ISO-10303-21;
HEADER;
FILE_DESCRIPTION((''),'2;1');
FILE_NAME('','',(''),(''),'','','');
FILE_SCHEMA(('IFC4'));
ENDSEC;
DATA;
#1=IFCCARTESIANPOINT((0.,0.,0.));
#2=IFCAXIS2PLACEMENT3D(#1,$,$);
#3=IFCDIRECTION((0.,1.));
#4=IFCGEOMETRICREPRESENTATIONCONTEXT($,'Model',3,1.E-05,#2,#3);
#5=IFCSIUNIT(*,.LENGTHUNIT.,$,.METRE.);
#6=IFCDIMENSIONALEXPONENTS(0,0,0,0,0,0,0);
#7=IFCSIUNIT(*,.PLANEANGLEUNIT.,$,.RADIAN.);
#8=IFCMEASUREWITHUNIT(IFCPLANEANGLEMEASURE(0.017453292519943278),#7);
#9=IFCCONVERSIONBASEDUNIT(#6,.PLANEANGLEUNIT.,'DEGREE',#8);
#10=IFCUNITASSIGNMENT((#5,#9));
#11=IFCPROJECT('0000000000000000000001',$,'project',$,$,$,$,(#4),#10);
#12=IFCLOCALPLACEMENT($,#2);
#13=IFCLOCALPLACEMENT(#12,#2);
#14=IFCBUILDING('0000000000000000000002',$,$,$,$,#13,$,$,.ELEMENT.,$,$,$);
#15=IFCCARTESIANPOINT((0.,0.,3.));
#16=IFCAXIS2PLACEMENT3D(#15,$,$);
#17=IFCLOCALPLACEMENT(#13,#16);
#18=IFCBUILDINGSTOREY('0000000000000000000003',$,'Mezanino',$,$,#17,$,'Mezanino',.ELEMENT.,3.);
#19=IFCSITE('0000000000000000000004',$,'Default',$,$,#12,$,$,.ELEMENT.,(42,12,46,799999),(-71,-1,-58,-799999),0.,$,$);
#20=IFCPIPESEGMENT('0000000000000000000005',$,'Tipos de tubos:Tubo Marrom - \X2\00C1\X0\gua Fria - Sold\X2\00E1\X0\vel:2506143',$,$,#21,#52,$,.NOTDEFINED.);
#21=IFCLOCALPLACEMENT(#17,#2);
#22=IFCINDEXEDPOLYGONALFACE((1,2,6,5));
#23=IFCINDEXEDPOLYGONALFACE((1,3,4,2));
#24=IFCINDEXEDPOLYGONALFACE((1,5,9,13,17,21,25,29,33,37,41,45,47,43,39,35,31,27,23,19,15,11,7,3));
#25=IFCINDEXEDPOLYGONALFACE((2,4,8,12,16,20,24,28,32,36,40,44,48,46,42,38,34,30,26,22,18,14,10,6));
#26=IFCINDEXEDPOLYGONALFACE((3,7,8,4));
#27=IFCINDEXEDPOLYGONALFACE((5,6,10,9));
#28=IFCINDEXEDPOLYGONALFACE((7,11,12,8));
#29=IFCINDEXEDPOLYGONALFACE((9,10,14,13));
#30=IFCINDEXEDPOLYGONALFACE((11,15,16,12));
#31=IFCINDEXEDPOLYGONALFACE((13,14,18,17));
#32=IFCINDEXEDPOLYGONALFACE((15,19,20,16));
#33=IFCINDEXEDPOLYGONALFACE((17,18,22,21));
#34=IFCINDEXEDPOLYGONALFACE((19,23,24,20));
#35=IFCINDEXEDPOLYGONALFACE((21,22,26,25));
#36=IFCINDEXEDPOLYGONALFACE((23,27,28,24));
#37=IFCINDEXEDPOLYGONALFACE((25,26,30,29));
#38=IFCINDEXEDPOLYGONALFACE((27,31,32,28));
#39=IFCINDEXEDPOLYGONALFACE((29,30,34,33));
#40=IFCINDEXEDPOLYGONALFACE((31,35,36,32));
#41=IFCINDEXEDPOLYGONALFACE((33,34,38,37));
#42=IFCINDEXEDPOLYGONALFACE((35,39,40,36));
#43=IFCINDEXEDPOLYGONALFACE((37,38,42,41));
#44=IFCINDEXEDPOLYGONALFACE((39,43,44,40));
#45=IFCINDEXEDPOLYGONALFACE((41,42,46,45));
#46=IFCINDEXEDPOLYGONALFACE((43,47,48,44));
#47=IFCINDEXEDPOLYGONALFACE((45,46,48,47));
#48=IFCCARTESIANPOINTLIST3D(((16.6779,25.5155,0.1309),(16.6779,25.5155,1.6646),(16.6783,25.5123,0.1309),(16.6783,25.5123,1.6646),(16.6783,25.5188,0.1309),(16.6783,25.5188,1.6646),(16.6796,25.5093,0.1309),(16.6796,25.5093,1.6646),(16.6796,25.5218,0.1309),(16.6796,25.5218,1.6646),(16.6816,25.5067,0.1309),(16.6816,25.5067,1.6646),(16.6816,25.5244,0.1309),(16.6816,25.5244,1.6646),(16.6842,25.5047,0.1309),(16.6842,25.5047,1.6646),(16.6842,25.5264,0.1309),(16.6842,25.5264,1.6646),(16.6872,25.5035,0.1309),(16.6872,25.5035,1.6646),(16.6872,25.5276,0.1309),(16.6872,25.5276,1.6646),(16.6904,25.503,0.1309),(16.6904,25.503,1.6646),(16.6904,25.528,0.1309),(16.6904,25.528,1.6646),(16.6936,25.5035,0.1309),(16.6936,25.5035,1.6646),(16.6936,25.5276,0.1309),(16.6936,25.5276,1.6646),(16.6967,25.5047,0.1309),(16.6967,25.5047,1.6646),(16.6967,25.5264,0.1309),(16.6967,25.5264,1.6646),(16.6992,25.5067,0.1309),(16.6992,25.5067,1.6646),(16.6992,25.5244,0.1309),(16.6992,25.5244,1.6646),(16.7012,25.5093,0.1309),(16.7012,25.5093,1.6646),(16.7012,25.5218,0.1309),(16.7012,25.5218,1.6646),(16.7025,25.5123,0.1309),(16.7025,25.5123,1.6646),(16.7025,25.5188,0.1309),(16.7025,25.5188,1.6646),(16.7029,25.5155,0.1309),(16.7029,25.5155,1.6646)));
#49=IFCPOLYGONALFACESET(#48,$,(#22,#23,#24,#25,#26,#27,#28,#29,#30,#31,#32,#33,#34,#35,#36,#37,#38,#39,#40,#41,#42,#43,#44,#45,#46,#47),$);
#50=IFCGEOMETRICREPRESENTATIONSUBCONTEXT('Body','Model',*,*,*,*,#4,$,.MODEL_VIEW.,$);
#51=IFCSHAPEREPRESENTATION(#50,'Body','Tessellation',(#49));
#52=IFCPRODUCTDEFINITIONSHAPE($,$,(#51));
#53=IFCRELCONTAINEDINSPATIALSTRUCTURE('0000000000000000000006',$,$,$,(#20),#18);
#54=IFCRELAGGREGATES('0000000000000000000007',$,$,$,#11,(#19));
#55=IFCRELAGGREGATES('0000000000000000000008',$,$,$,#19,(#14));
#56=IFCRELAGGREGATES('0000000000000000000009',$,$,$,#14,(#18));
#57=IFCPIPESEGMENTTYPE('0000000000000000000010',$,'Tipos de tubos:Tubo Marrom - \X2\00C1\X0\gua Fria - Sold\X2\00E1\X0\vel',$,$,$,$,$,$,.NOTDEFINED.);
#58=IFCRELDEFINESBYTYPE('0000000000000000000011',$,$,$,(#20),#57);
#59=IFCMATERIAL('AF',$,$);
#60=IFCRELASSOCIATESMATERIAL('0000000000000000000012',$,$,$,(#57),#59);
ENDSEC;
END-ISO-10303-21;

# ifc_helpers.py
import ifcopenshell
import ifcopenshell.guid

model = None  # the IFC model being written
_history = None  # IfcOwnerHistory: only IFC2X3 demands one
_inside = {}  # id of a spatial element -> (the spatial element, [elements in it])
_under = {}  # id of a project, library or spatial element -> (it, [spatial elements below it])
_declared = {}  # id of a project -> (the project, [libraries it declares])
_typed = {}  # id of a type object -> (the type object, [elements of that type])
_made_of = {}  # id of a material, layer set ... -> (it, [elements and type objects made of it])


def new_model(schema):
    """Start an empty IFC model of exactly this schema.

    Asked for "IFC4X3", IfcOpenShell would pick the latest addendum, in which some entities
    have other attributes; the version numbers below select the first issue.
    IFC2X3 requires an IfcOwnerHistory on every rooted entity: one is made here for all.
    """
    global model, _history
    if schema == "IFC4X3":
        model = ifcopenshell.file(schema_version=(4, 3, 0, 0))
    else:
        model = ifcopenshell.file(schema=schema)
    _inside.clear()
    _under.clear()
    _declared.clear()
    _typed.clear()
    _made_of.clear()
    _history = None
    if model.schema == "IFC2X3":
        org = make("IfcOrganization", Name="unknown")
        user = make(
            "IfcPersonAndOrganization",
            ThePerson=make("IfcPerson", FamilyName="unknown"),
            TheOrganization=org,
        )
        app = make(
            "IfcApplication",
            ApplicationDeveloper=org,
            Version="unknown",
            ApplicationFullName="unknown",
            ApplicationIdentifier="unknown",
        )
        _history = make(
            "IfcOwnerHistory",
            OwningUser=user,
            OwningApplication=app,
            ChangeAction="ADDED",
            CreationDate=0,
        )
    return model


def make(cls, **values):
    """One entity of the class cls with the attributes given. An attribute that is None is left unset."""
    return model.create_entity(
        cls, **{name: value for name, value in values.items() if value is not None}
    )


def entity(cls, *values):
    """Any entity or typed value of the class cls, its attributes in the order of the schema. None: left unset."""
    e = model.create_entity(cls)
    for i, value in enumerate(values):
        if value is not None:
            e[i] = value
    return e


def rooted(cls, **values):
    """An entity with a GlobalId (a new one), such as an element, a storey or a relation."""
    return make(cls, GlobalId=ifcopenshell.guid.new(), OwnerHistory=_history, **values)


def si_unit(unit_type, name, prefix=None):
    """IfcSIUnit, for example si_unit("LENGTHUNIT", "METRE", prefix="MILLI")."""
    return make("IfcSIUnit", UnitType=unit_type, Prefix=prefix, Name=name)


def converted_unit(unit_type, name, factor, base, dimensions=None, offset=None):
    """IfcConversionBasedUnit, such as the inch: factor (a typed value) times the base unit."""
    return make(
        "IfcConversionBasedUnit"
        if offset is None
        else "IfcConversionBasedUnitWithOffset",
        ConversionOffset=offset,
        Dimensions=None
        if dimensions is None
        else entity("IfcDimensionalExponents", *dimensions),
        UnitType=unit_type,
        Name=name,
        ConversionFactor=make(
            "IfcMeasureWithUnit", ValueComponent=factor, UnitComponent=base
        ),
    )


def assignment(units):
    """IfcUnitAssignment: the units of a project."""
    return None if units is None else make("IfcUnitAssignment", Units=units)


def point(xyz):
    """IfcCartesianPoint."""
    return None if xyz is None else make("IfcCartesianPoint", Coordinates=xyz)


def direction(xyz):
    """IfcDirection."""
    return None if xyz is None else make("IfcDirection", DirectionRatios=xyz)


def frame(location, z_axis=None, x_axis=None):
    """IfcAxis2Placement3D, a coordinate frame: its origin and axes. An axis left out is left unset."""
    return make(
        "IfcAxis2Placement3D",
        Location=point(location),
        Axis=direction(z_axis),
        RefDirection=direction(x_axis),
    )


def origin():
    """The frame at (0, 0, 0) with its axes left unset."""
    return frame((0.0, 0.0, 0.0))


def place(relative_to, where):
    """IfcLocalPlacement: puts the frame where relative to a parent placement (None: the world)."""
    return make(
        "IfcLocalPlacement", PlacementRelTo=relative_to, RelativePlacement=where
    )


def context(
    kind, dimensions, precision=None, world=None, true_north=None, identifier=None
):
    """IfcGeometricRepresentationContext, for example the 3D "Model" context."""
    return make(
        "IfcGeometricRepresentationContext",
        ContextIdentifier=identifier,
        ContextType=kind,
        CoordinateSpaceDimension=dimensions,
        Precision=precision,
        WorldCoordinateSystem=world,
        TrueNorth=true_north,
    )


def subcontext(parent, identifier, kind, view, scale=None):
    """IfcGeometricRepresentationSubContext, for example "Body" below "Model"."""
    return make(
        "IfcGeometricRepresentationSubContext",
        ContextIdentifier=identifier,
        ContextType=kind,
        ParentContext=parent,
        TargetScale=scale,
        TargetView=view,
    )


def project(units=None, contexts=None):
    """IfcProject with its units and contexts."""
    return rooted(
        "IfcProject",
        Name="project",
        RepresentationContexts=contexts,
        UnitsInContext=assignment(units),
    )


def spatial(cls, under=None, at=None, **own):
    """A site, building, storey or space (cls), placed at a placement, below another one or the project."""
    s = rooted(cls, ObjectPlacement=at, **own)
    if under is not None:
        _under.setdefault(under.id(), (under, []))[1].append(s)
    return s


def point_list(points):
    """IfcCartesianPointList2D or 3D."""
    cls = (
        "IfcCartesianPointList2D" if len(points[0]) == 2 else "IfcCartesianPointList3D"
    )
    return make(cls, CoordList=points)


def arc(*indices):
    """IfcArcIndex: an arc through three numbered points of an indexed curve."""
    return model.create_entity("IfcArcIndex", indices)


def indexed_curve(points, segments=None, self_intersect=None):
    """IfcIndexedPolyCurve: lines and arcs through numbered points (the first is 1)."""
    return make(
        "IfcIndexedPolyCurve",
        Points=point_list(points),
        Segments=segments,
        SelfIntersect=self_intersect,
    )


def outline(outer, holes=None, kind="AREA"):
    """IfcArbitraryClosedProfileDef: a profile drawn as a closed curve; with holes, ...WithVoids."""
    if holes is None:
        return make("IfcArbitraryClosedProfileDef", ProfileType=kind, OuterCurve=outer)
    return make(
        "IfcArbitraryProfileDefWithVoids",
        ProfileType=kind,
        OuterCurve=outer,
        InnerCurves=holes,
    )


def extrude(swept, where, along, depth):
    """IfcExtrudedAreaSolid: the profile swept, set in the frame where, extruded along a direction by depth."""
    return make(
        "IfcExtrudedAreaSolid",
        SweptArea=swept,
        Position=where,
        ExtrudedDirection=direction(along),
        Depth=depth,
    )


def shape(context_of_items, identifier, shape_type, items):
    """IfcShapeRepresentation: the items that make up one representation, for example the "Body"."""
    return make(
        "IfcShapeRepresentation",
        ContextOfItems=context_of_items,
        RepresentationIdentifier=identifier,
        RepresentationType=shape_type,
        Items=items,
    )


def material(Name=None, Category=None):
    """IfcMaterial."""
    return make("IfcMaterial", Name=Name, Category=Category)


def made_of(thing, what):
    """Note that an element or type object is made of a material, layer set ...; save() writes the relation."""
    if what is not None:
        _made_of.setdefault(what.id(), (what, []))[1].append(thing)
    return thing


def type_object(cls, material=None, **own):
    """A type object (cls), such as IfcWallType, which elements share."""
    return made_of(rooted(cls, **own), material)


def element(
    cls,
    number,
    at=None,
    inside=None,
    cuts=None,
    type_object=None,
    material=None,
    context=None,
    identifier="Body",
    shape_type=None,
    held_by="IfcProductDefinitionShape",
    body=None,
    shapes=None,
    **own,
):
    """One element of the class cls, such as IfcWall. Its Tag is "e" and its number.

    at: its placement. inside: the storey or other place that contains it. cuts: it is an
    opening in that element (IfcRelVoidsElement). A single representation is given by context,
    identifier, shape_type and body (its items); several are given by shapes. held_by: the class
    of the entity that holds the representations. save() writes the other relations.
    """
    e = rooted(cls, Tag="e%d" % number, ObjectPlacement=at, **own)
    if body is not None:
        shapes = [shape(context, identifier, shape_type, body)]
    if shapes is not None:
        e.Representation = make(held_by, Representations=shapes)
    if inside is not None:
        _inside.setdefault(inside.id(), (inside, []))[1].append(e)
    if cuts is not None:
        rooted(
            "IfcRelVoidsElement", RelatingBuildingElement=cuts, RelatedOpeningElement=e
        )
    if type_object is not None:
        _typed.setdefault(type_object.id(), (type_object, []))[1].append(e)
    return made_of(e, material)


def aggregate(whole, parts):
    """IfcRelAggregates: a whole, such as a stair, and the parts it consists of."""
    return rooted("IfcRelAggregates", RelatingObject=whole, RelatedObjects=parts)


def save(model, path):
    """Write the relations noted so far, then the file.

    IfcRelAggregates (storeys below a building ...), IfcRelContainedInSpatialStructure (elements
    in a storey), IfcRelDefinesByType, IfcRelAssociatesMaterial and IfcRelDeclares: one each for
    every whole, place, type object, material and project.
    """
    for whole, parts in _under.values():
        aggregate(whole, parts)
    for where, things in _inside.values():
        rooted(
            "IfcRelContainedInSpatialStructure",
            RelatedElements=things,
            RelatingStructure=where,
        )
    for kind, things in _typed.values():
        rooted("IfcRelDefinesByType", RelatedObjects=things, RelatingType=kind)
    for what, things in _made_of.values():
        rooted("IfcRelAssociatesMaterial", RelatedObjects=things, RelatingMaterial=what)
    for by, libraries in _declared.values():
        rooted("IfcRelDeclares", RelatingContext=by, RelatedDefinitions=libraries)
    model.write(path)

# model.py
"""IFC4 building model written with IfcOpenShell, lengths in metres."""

from ifc_helpers import new_model, entity, si_unit, converted_unit, direction, frame, origin, place, context, subcontext, project, spatial, arc, indexed_curve, outline, extrude, material, type_object, element, save


model = new_model("IFC4")

# Units and contexts
model_context = context("Model", 3, precision=1e-05, world=origin(), true_north=direction((0.0, 1.0)))
body_context = subcontext(model_context, "Body", "Model", "MODEL_VIEW")
ifc_project = project(units=[si_unit("LENGTHUNIT", "METRE"), converted_unit("PLANEANGLEUNIT", "DEGREE", entity("IfcPlaneAngleMeasure", 0.017453292519943278), si_unit("PLANEANGLEUNIT", "RADIAN"), dimensions=[0, 0, 0, 0, 0, 0, 0])], contexts=[model_context])

# Site, building, storey
site_placement = place(None, origin())
site = spatial("IfcSite", under=ifc_project, at=site_placement, Name="Default", CompositionType="ELEMENT", RefLatitude=(42, 12, 46, 799999), RefLongitude=(-71, -1, -58, -799999), RefElevation=0.0)
building_placement = place(site_placement, origin())
building = spatial("IfcBuilding", under=site, at=building_placement, CompositionType="ELEMENT")
storey_placement = place(building_placement, frame((0.0, 0.0, 3.0)))
storey = spatial("IfcBuildingStorey", under=building, at=storey_placement, Name="Mezanino", LongName="Mezanino", CompositionType="ELEMENT", Elevation=3.0)

# Pipe segment
ifc_material = material(Name="AF")
pipe_segment_type = type_object("IfcPipeSegmentType", Name="Tipos de tubos:Tubo Marrom - Água Fria - Soldável", PredefinedType="NOTDEFINED", material=ifc_material)
pipe_segment_1_placement = place(storey_placement, origin())
element("IfcPipeSegment", 1, at=pipe_segment_1_placement, inside=storey, type_object=pipe_segment_type, Name="Tipos de tubos:Tubo Marrom - Água Fria - Soldável:2506143", PredefinedType="NOTDEFINED", context=body_context, shape_type="SweptSolid", body=[
    extrude(outline(indexed_curve([(0.0125, 0.0), (0.0088, 0.0088), (0.0, 0.0125), (-0.0088, 0.0088), (-0.0125, 0.0), (-0.0088, -0.0088), (0.0, -0.0125), (0.0088, -0.0088)], segments=[arc(1, 2, 3), arc(3, 4, 5), arc(5, 6, 7), arc(7, 8, 1)], self_intersect=False)), frame((16.6904, 25.5155, 0.1309)), (0.0, 0.0, 1.0), 1.5337),
])

save(model, "model.ifc")
